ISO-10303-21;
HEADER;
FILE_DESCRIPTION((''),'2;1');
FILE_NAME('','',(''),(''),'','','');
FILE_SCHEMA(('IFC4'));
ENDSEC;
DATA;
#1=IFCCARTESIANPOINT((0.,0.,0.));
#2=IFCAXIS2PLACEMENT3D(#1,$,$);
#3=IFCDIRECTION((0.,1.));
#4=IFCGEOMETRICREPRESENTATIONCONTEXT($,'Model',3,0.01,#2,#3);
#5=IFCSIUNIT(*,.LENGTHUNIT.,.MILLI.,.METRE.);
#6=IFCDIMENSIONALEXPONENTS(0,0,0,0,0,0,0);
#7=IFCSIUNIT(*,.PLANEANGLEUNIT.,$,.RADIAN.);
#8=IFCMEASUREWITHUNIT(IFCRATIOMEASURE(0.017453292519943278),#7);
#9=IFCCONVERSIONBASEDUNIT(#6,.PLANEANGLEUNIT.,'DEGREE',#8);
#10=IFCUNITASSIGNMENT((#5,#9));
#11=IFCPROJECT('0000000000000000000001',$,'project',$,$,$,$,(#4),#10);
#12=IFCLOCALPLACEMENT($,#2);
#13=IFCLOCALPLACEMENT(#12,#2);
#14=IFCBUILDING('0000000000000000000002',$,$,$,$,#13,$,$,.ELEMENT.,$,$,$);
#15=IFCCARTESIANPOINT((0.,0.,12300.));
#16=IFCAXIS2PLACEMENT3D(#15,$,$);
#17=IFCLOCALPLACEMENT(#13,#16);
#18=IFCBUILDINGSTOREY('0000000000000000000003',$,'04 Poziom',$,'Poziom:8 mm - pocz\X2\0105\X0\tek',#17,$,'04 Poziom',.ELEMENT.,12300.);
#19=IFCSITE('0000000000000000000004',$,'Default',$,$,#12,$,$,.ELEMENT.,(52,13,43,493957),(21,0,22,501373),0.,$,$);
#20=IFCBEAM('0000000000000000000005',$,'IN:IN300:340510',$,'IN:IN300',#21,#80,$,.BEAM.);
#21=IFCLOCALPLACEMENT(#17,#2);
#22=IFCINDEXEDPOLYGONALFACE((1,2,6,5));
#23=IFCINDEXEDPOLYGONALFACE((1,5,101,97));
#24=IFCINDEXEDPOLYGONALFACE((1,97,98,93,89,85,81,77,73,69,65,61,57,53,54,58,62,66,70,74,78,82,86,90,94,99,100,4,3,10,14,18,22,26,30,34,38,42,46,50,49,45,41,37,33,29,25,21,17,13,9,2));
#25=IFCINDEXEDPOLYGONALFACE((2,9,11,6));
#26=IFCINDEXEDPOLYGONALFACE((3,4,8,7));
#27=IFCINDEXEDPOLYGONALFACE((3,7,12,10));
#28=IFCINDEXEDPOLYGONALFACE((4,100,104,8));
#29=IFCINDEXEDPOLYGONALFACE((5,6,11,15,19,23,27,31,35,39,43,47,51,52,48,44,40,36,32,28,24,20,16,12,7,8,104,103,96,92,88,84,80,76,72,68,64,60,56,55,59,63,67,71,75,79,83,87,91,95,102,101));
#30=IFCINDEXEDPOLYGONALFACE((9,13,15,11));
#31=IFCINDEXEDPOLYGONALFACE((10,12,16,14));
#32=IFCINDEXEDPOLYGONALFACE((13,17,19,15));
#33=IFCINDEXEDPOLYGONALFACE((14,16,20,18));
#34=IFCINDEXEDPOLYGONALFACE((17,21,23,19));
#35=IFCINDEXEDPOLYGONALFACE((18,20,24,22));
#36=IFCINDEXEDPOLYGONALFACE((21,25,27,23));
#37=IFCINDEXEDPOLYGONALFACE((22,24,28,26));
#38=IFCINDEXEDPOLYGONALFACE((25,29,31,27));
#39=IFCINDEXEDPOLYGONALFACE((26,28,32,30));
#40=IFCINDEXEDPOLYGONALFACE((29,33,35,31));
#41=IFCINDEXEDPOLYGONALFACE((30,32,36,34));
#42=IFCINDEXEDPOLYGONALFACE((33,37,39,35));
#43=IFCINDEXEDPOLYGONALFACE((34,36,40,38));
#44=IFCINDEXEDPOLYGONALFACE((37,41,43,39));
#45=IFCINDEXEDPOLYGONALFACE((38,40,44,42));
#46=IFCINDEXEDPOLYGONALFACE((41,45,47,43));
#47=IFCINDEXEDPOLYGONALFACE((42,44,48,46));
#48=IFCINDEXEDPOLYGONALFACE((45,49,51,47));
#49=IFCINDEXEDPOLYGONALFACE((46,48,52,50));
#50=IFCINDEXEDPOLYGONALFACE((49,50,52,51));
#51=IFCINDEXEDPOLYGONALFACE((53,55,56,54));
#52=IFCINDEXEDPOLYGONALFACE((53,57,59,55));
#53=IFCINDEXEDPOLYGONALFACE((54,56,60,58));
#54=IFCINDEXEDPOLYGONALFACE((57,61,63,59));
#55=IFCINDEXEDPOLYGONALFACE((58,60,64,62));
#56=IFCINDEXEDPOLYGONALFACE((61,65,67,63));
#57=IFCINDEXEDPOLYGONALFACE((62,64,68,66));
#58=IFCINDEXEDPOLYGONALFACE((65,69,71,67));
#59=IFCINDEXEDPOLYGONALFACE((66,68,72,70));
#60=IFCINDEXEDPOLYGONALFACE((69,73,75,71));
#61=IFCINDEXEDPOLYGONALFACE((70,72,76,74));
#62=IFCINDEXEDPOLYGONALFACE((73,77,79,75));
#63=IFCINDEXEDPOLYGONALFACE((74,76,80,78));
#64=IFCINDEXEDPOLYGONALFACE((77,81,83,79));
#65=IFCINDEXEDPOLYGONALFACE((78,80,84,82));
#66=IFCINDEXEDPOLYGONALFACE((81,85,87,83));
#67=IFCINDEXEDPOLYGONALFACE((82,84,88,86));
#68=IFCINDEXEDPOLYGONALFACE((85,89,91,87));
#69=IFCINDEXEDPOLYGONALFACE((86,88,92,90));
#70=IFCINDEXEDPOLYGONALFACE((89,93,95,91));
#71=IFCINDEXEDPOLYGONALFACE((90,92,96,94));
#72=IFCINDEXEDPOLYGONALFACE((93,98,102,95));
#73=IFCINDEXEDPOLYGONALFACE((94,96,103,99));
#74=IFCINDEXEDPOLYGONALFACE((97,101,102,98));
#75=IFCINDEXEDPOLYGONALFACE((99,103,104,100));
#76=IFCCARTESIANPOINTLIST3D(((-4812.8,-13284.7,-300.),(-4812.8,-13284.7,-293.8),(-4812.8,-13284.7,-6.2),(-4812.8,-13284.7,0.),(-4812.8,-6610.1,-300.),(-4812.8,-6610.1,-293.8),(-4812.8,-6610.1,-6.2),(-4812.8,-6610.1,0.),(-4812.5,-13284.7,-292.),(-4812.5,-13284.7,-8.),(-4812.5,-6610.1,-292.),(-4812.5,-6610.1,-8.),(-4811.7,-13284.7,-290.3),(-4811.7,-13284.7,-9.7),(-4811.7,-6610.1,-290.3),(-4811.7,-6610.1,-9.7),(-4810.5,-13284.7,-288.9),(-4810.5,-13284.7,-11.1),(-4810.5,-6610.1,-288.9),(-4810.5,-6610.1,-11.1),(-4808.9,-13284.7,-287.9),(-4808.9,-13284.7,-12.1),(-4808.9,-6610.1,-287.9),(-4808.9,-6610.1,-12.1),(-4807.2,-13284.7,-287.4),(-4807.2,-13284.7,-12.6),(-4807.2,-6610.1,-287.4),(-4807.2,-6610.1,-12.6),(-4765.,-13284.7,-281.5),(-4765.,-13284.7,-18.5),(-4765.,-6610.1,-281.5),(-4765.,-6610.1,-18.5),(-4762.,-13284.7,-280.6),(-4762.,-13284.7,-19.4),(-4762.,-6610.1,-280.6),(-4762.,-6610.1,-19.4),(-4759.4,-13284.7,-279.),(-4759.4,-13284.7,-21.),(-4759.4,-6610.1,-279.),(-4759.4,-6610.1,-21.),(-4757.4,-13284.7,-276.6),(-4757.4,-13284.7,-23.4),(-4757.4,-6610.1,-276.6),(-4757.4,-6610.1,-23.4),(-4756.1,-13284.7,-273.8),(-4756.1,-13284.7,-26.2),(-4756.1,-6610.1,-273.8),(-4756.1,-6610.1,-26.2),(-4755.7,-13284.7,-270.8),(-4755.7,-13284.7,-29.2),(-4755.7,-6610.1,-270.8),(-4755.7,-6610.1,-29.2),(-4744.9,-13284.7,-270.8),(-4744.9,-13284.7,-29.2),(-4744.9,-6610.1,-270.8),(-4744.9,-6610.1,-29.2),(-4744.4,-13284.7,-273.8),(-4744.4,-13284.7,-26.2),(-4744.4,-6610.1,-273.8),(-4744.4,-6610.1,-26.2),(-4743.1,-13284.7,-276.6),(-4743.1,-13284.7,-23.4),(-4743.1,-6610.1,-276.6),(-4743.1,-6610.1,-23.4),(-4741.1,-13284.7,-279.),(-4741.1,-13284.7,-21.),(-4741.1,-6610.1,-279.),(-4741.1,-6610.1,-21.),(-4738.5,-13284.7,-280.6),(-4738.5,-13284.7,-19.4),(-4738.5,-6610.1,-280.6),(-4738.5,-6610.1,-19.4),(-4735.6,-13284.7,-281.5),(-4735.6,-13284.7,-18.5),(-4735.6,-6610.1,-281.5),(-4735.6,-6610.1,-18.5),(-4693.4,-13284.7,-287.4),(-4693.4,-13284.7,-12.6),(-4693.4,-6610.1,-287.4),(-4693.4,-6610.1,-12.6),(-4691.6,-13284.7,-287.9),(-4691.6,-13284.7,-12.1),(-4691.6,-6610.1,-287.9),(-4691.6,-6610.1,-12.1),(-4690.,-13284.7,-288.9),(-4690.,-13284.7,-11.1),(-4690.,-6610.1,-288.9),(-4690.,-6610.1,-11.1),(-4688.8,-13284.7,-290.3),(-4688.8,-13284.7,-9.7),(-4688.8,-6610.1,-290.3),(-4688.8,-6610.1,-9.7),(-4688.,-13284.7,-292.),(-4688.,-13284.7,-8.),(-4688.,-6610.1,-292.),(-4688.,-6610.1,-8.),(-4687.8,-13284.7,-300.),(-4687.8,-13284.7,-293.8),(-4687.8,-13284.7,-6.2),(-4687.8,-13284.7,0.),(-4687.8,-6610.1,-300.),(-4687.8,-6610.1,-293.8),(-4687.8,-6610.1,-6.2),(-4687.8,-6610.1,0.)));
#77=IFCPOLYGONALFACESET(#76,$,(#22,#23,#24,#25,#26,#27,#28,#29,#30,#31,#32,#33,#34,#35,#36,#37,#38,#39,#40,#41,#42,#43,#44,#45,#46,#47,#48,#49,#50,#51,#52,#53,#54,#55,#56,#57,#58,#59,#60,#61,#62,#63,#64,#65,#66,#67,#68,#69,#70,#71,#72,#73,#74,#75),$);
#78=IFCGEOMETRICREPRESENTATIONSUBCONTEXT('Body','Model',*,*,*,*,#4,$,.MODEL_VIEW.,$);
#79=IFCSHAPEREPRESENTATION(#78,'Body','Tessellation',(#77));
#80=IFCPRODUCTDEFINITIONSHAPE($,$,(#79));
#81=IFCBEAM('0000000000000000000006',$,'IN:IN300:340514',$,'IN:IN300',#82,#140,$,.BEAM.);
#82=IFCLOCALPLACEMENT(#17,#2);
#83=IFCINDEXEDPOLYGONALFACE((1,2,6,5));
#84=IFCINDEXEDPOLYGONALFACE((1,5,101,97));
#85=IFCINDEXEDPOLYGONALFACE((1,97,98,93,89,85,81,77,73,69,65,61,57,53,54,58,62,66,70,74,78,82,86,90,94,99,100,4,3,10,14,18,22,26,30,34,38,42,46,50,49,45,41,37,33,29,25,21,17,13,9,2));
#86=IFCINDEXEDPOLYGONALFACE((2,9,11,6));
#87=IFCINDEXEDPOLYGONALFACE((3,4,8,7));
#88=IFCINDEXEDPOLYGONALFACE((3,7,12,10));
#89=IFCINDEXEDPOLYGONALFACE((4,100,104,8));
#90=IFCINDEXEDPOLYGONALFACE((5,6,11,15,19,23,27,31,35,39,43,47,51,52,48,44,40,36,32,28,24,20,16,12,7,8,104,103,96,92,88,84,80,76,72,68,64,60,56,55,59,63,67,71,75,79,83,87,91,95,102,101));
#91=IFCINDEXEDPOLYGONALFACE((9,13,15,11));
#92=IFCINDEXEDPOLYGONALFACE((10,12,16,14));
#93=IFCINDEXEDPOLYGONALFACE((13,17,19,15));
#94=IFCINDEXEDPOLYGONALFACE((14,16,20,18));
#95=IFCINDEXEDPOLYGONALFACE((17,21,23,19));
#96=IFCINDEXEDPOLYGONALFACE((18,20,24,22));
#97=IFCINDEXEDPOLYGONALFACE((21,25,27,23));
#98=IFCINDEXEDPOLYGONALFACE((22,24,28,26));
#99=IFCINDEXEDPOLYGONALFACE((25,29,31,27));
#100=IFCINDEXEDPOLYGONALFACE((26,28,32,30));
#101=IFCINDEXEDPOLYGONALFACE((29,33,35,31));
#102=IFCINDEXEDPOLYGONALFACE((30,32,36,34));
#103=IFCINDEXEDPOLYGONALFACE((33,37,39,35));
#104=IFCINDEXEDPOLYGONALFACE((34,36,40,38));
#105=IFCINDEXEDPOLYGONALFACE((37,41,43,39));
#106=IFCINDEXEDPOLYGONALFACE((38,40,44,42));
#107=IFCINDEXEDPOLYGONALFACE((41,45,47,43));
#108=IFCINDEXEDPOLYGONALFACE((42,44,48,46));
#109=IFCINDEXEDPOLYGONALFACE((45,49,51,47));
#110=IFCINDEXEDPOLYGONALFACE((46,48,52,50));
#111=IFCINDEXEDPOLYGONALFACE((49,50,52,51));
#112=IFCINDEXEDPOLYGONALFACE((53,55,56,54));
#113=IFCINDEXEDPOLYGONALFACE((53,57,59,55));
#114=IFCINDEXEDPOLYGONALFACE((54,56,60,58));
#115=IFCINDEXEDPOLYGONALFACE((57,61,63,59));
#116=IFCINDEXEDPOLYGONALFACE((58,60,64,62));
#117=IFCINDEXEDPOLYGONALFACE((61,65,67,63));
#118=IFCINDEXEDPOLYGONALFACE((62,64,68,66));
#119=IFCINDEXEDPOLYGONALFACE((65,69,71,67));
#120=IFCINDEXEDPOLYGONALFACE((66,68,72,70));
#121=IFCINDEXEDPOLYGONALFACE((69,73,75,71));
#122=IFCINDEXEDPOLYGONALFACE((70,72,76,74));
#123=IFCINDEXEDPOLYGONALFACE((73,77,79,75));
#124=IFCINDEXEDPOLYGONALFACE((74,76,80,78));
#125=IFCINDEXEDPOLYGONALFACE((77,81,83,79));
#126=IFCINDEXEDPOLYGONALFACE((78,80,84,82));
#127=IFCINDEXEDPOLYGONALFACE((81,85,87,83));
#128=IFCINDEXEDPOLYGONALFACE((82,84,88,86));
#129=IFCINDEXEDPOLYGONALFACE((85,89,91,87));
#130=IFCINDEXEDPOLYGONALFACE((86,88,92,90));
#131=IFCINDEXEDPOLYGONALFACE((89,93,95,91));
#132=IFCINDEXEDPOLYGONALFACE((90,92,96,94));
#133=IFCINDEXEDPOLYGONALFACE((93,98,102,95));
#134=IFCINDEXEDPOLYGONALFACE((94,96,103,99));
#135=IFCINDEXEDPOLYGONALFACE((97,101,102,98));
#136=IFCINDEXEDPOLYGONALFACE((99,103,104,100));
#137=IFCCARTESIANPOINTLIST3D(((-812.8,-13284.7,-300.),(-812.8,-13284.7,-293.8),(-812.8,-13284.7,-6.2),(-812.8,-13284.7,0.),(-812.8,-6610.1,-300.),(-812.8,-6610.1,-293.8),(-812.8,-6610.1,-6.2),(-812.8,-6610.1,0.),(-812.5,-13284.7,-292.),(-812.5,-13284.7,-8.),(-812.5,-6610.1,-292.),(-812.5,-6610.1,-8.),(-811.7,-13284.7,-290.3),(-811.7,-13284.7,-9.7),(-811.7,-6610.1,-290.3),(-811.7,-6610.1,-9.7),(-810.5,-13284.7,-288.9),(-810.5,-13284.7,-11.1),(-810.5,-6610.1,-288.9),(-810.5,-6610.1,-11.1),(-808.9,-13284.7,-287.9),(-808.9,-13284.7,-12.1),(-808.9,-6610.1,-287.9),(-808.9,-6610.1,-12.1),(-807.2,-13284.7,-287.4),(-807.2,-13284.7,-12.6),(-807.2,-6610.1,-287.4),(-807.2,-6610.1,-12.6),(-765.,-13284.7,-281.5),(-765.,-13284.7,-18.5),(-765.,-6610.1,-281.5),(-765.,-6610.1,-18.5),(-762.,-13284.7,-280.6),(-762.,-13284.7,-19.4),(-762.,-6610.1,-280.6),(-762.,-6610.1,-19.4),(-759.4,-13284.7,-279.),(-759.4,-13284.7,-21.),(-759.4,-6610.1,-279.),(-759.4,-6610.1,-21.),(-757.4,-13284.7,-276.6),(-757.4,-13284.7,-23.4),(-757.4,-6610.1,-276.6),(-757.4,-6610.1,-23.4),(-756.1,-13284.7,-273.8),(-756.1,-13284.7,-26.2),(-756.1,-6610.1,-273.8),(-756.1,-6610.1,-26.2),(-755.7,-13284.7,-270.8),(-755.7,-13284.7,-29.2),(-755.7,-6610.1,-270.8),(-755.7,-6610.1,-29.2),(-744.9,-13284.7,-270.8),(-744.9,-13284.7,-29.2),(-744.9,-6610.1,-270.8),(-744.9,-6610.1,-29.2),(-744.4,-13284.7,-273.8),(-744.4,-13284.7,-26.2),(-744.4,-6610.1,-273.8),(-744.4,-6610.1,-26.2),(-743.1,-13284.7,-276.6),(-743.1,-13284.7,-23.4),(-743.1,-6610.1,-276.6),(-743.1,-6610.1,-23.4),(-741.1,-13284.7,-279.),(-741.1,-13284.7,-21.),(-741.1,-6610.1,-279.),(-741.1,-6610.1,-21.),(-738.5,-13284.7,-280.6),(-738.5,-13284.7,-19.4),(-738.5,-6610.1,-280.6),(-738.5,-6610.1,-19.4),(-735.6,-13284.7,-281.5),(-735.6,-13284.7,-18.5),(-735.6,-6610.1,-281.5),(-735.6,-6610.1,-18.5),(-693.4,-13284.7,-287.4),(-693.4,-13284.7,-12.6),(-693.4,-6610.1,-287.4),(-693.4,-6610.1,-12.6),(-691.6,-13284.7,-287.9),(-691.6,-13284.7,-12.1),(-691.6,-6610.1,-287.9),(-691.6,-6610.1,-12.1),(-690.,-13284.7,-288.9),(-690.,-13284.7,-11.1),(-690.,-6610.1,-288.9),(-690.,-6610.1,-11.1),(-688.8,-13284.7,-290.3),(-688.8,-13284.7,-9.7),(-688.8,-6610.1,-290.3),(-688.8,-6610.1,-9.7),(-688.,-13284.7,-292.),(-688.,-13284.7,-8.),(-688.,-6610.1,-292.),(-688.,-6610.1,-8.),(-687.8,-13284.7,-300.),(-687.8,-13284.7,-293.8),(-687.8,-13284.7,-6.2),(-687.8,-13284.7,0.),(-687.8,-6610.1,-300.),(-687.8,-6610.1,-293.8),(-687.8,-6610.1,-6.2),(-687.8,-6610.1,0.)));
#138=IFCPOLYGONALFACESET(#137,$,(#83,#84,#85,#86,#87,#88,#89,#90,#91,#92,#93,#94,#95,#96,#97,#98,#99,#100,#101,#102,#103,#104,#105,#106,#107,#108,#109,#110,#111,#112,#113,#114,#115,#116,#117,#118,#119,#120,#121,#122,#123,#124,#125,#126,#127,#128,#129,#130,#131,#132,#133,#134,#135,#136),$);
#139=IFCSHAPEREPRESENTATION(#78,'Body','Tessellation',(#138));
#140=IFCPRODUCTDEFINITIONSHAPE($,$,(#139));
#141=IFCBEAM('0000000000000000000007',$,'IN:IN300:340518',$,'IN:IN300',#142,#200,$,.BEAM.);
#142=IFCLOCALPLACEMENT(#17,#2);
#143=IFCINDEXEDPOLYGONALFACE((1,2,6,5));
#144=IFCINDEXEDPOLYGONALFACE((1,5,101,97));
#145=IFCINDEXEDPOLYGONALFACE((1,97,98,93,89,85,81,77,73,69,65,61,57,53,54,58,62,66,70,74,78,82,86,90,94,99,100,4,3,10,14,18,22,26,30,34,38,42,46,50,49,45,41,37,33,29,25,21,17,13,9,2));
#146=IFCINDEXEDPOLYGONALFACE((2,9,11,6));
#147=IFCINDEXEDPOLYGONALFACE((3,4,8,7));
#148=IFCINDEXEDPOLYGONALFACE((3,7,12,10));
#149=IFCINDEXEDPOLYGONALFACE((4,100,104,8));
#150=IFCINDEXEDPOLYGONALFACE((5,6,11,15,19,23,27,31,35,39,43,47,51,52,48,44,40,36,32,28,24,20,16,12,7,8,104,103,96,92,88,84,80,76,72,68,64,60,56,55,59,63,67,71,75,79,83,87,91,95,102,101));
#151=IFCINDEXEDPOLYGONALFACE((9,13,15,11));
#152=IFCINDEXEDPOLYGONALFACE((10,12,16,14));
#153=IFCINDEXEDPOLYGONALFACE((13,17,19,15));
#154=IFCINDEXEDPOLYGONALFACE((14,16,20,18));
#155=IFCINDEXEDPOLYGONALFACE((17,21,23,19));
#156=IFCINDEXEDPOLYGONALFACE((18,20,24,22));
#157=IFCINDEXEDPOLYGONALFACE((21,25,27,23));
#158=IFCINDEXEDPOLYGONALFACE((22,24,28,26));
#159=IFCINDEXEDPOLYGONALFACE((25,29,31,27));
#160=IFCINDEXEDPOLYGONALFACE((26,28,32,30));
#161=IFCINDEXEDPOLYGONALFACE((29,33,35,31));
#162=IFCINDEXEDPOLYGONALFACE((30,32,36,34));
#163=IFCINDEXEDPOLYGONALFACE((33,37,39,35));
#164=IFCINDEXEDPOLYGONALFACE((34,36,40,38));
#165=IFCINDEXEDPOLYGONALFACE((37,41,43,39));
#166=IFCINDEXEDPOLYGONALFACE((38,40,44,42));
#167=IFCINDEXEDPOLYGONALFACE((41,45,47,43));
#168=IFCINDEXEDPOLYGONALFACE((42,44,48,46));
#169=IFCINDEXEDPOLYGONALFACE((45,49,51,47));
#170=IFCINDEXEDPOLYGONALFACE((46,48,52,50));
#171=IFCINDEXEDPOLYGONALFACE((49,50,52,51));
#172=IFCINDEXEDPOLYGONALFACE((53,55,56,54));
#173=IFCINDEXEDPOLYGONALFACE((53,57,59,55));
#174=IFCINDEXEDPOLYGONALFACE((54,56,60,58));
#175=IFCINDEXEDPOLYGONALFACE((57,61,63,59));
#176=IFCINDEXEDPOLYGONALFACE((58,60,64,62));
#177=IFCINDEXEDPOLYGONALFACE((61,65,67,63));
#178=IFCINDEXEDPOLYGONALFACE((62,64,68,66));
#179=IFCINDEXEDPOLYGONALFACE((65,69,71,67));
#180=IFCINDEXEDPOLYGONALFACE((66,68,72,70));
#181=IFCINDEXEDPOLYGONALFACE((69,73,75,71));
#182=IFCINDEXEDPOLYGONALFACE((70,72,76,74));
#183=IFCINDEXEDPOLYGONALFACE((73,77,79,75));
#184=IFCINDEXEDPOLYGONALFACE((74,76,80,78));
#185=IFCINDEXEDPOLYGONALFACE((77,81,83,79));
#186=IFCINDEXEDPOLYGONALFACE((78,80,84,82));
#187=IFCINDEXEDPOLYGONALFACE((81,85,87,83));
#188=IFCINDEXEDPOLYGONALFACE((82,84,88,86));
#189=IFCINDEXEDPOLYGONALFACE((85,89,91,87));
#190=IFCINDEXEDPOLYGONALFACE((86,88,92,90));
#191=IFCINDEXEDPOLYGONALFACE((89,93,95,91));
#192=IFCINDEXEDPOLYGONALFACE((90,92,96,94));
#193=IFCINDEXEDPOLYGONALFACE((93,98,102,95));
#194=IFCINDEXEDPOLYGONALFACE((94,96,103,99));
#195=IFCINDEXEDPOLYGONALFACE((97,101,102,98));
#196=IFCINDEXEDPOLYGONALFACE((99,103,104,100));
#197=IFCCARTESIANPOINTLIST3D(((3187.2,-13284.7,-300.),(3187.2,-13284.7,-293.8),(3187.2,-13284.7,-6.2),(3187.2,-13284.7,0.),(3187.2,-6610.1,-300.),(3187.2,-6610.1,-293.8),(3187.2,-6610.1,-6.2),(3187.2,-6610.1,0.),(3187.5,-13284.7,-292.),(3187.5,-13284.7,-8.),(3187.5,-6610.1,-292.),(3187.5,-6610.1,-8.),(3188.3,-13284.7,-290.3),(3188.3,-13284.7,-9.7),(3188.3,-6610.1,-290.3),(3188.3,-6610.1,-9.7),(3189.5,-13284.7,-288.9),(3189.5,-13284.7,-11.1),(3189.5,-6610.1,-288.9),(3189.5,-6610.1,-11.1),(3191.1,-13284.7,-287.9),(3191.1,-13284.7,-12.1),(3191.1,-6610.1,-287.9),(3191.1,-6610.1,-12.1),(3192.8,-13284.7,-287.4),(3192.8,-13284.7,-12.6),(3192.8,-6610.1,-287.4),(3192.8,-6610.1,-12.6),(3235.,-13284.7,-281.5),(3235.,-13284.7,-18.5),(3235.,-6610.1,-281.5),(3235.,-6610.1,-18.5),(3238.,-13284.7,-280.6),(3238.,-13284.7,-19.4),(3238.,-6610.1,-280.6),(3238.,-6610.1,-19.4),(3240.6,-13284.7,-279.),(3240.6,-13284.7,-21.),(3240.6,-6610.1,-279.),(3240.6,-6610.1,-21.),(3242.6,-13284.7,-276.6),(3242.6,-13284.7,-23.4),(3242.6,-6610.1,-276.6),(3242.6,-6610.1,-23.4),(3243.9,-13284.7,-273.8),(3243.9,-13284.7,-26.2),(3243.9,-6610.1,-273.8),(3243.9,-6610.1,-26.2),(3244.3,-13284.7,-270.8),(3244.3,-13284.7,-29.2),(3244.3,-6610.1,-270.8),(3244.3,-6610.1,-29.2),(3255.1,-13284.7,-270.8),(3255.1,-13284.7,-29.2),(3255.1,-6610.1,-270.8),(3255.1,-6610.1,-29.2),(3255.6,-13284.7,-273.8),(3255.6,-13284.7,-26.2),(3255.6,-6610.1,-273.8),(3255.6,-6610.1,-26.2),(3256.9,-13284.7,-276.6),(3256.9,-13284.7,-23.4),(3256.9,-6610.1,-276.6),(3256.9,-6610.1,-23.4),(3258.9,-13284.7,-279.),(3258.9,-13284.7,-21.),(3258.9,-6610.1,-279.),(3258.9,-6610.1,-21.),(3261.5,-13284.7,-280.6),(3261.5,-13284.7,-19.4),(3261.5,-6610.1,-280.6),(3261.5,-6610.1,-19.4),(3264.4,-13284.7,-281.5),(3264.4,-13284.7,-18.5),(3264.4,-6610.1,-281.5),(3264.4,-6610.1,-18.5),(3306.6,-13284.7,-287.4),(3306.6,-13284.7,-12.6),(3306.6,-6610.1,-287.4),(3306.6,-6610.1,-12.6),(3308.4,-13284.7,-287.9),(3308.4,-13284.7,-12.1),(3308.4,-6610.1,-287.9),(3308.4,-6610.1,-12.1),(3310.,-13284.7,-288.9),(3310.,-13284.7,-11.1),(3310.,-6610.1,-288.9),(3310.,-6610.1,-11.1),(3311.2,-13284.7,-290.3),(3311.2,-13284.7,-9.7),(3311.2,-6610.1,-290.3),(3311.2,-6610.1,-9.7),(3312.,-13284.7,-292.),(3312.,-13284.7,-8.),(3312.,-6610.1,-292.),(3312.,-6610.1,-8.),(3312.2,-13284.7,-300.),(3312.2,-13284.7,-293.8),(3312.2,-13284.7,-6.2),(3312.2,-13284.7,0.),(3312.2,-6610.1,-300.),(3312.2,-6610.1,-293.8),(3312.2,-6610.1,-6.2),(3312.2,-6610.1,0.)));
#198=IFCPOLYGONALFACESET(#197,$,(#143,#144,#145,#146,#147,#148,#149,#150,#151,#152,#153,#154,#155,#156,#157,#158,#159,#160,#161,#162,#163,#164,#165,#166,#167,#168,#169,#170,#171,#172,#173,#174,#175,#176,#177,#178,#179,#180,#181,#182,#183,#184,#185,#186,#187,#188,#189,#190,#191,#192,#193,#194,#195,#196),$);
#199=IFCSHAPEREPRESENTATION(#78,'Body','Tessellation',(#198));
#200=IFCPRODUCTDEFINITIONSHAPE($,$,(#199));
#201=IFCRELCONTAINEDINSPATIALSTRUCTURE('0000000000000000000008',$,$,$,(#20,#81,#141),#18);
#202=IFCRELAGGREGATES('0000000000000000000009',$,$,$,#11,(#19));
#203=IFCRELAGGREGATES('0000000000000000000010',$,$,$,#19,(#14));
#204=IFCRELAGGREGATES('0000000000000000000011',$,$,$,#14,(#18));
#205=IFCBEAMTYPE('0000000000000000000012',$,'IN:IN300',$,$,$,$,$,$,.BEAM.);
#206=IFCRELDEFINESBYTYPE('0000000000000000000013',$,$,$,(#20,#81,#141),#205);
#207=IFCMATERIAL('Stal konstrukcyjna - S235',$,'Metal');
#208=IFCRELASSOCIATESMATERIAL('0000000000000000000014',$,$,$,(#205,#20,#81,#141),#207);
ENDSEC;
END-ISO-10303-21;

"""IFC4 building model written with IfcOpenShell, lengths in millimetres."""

from ifc_helpers import new_model, entity, si_unit, converted_unit, direction, frame, origin, place, context, subcontext, project, spatial, line, arc, indexed_curve, outline, extrude, source, transform, mapped, material, type_object, type_shapes, element, save


model = new_model("IFC4")

# Units and contexts
model_context = context("Model", 3, precision=0.01, world=origin(), true_north=direction((0.0, 1.0)))
body_context = subcontext(model_context, "Body", "Model", "MODEL_VIEW")
ifc_project = project(units=[si_unit("LENGTHUNIT", "METRE", prefix="MILLI"), converted_unit("PLANEANGLEUNIT", "DEGREE", entity("IfcRatioMeasure", 0.017453292519943278), si_unit("PLANEANGLEUNIT", "RADIAN"), dimensions=[0, 0, 0, 0, 0, 0, 0])], contexts=[model_context])

# Site, building, storey
site_placement = place(None, origin())
site = spatial("IfcSite", under=ifc_project, at=site_placement, Name="Default", CompositionType="ELEMENT", RefLatitude=(52, 13, 43, 493957), RefLongitude=(21, 0, 22, 501373), RefElevation=0.0)
building_placement = place(site_placement, origin())
building = spatial("IfcBuilding", under=site, at=building_placement, CompositionType="ELEMENT")
storey_placement = place(building_placement, frame((0.0, 0.0, 12300.0)))
storey = spatial("IfcBuildingStorey", under=building, at=storey_placement, Name="04 Poziom", ObjectType="Poziom:8 mm - początek", LongName="04 Poziom", CompositionType="ELEMENT", Elevation=12300.0)

# Shared definitions
ifc_material = material(Name="Stal konstrukcyjna - S235", Category="Metal")

# Beams
beam_type_1 = type_object("IfcBeamType", Name="IN:IN300", PredefinedType="BEAM", material=ifc_material)
shared_shape_1 = source(origin(), body_context, "Body", "SweptSolid", [
    extrude(outline(indexed_curve([(143.8, -62.5), (150.0, -62.5), (150.0, 62.5), (143.8, 62.5), (139.6, 60.9), (137.4, 56.9), (131.5, 14.7), (127.9, 8.1), (120.8, 5.4), (-120.8, 5.4), (-127.9, 8.1), (-131.5, 14.7), (-137.4, 56.9), (-139.6, 60.9), (-143.8, 62.5), (-150.0, 62.5), (-150.0, -62.5), (-143.8, -62.5), (-139.6, -60.9), (-137.4, -56.9), (-131.5, -14.7), (-127.9, -8.1), (-120.8, -5.4), (120.8, -5.4), (127.9, -8.1), (131.5, -14.7), (137.4, -56.9), (139.6, -60.9)], segments=[line(1, 2, 3, 4), arc(4, 5, 6), line(6, 7), arc(7, 8, 9), line(9, 10), arc(10, 11, 12), line(12, 13), arc(13, 14, 15), line(15, 16, 17, 18), arc(18, 19, 20), line(20, 21), arc(21, 22, 23), line(23, 24), arc(24, 25, 26), line(26, 27), arc(27, 28, 1)], self_intersect=False)), frame((-3337.3, 0.0, 0.0), z_axis=(1.0, 0.0, 0.0), x_axis=(0.0, 0.0, -1.0)), (0.0, 0.0, 1.0), 6674.6),
])
type_shapes(beam_type_1, [shared_shape_1])
for number, where, z_axis, x_axis, name in (
    (1, (-4750.3, -9947.4, -150.0), (0.0, 0.0, 1.0), (0.0, -1.0, 0.0), "IN:IN300:340510"),
    (2, (-750.3, -9947.4, -150.0), (0.0, 0.0, 1.0), (0.0, -1.0, 0.0), "IN:IN300:340514"),
    (3, (3249.7, -9947.4, -150.0), (0.0, 0.0, 1.0), (0.0, -1.0, 0.0), "IN:IN300:340518"),
):
    element("IfcBeam", number, at=place(storey_placement, frame(where, z_axis=z_axis, x_axis=x_axis)), inside=storey, type_object=beam_type_1, material=ifc_material, Name=name, ObjectType="IN:IN300", PredefinedType="BEAM", context=body_context, shape_type="MappedRepresentation", body=[
        mapped(shared_shape_1, transform((0.0, 0.0, 0.0), scale=1.0)),
    ])

save(model, "model.ifc")
